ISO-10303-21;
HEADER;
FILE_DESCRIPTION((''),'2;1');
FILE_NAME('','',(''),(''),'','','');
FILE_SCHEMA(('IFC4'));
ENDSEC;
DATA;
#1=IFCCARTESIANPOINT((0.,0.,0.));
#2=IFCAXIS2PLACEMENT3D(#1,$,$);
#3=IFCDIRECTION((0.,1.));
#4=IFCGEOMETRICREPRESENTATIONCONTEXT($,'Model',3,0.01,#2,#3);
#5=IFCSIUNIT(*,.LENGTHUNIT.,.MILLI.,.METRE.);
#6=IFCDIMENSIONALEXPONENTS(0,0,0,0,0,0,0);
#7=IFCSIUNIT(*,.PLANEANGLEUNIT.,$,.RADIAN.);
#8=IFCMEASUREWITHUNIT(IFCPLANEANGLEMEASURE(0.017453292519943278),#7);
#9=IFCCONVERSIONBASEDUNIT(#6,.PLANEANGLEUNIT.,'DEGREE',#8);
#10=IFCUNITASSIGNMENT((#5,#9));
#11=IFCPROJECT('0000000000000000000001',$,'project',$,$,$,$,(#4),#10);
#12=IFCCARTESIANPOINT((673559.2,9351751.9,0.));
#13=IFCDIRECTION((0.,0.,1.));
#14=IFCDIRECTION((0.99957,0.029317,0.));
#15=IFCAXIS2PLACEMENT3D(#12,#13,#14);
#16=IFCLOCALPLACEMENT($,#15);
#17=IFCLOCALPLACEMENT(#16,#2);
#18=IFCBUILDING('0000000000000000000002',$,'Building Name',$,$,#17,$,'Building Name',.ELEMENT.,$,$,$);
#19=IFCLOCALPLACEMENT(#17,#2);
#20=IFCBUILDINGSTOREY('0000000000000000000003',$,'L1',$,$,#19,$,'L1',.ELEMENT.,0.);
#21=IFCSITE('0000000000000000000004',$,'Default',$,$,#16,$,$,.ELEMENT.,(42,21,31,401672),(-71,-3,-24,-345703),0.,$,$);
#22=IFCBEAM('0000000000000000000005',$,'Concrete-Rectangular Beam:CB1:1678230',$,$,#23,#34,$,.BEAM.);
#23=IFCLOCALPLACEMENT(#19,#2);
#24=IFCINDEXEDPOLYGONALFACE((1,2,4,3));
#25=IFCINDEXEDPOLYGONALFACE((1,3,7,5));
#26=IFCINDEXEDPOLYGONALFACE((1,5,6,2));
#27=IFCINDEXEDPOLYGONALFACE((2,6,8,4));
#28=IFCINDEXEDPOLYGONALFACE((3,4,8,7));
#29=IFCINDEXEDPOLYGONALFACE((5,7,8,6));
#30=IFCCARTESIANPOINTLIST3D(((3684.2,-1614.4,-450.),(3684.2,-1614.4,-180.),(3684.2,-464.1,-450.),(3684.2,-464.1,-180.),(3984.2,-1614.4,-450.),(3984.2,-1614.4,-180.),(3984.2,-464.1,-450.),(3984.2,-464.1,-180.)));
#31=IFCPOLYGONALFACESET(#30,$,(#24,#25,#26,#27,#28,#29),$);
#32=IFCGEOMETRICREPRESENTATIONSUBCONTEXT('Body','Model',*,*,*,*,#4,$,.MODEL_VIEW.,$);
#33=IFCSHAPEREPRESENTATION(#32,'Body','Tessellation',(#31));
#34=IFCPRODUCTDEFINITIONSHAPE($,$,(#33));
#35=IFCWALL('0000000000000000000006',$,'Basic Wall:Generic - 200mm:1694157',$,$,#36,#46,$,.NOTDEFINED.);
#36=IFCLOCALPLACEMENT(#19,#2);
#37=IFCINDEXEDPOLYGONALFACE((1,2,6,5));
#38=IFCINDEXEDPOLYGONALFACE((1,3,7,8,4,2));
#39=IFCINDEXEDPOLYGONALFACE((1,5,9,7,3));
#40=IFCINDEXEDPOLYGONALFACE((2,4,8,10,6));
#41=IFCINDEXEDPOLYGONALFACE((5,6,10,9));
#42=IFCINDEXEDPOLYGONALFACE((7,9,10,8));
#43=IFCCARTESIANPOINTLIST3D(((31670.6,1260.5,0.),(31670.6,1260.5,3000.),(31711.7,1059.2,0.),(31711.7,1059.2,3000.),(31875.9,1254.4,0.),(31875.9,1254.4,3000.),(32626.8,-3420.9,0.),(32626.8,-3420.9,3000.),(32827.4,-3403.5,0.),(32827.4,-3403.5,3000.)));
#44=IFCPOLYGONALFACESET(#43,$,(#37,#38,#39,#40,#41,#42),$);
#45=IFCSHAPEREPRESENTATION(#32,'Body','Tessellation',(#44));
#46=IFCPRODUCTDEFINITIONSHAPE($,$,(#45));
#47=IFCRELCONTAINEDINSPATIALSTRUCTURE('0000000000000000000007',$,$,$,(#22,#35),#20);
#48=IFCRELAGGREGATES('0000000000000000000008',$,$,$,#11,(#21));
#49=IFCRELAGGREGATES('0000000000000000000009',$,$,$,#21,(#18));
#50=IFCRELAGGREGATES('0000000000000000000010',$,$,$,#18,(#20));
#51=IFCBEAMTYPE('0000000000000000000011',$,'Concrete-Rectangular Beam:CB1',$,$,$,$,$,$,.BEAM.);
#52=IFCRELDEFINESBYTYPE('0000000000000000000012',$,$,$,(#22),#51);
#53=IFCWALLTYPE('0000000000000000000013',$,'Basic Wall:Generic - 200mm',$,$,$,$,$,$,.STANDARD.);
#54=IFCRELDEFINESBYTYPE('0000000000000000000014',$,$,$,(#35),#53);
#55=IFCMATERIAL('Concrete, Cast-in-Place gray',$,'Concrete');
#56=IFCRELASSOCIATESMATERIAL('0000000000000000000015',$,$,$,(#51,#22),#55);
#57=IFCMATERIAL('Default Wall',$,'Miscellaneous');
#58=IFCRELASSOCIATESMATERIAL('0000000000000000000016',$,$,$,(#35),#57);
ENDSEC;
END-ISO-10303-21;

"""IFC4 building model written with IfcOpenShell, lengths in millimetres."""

from ifc_helpers import new_model, entity, si_unit, converted_unit, direction, frame, origin, place, context, subcontext, project, spatial, indexed_curve, outline, extrude, source, transform, mapped, material, type_object, type_shapes, element, save


model = new_model("IFC4")

# Units and contexts
model_context = context("Model", 3, precision=0.01, world=origin(), true_north=direction((0.0, 1.0)))
body_context = subcontext(model_context, "Body", "Model", "MODEL_VIEW")
ifc_project = project(units=[si_unit("LENGTHUNIT", "METRE", prefix="MILLI"), converted_unit("PLANEANGLEUNIT", "DEGREE", entity("IfcPlaneAngleMeasure", 0.017453292519943278), si_unit("PLANEANGLEUNIT", "RADIAN"), dimensions=[0, 0, 0, 0, 0, 0, 0])], contexts=[model_context])

# Site, building, storey
site_placement = place(None, frame((673559.2, 9351751.9, 0.0), z_axis=(0.0, 0.0, 1.0), x_axis=(0.99957, 0.029317, 0.0)))
site = spatial("IfcSite", under=ifc_project, at=site_placement, Name="Default", CompositionType="ELEMENT", RefLatitude=(42, 21, 31, 401672), RefLongitude=(-71, -3, -24, -345703), RefElevation=0.0)
building_placement = place(site_placement, origin())
building = spatial("IfcBuilding", under=site, at=building_placement, Name="Building Name", LongName="Building Name", CompositionType="ELEMENT")
storey_placement = place(building_placement, origin())
storey = spatial("IfcBuildingStorey", under=building, at=storey_placement, Name="L1", LongName="L1", CompositionType="ELEMENT", Elevation=0.0)

# Shared definitions
ifc_material_1 = material(Name="Concrete, Cast-in-Place gray", Category="Concrete")

# Beam
beam_type_1 = type_object("IfcBeamType", Name="Concrete-Rectangular Beam:CB1", PredefinedType="BEAM", material=ifc_material_1)
shared_shape_1 = source(origin(), body_context, "Body", "SweptSolid", [
    extrude(outline(indexed_curve([(-150.0, -135.0), (150.0, -135.0), (150.0, 135.0), (-150.0, 135.0), (-150.0, -135.0)], self_intersect=False)), frame((3834.2, -1614.4, -315.0), z_axis=(0.0, 1.0, 0.0), x_axis=(-1.0, 0.0, 0.0)), (0.0, 0.0, 1.0), 1150.4),
])
type_shapes(beam_type_1, [shared_shape_1])
beam_1_placement = place(storey_placement, origin())
element("IfcBeam", 1, at=beam_1_placement, inside=storey, type_object=beam_type_1, material=ifc_material_1, Name="Concrete-Rectangular Beam:CB1:1678230", PredefinedType="BEAM", context=body_context, shape_type="MappedRepresentation", body=[
    mapped(shared_shape_1, transform((0.0, 0.0, 0.0), scale=1.0)),
])

# Wall
ifc_material_2 = material(Name="Default Wall", Category="Miscellaneous")
wall_type = type_object("IfcWallType", Name="Basic Wall:Generic - 200mm", PredefinedType="STANDARD")
wall_placement = place(storey_placement, frame((32729.5, -3423.6, 0.0), z_axis=(0.0, 0.0, 1.0), x_axis=(-0.200139, 0.979768, 0.0)))
element("IfcWall", 2, at=wall_placement, inside=storey, type_object=wall_type, material=ifc_material_2, Name="Basic Wall:Generic - 200mm:1694157", PredefinedType="NOTDEFINED", context=body_context, shape_type="SweptSolid", body=[
    extrude(outline(indexed_curve([(4754.2, -100.0), (4801.2, 100.0), (4595.7, 100.0), (23.2, 100.0), (0.0, -100.0), (4754.2, -100.0)], self_intersect=False)), origin(), (0.0, 0.0, 1.0), 3000.0),
])

save(model, "model.ifc")
